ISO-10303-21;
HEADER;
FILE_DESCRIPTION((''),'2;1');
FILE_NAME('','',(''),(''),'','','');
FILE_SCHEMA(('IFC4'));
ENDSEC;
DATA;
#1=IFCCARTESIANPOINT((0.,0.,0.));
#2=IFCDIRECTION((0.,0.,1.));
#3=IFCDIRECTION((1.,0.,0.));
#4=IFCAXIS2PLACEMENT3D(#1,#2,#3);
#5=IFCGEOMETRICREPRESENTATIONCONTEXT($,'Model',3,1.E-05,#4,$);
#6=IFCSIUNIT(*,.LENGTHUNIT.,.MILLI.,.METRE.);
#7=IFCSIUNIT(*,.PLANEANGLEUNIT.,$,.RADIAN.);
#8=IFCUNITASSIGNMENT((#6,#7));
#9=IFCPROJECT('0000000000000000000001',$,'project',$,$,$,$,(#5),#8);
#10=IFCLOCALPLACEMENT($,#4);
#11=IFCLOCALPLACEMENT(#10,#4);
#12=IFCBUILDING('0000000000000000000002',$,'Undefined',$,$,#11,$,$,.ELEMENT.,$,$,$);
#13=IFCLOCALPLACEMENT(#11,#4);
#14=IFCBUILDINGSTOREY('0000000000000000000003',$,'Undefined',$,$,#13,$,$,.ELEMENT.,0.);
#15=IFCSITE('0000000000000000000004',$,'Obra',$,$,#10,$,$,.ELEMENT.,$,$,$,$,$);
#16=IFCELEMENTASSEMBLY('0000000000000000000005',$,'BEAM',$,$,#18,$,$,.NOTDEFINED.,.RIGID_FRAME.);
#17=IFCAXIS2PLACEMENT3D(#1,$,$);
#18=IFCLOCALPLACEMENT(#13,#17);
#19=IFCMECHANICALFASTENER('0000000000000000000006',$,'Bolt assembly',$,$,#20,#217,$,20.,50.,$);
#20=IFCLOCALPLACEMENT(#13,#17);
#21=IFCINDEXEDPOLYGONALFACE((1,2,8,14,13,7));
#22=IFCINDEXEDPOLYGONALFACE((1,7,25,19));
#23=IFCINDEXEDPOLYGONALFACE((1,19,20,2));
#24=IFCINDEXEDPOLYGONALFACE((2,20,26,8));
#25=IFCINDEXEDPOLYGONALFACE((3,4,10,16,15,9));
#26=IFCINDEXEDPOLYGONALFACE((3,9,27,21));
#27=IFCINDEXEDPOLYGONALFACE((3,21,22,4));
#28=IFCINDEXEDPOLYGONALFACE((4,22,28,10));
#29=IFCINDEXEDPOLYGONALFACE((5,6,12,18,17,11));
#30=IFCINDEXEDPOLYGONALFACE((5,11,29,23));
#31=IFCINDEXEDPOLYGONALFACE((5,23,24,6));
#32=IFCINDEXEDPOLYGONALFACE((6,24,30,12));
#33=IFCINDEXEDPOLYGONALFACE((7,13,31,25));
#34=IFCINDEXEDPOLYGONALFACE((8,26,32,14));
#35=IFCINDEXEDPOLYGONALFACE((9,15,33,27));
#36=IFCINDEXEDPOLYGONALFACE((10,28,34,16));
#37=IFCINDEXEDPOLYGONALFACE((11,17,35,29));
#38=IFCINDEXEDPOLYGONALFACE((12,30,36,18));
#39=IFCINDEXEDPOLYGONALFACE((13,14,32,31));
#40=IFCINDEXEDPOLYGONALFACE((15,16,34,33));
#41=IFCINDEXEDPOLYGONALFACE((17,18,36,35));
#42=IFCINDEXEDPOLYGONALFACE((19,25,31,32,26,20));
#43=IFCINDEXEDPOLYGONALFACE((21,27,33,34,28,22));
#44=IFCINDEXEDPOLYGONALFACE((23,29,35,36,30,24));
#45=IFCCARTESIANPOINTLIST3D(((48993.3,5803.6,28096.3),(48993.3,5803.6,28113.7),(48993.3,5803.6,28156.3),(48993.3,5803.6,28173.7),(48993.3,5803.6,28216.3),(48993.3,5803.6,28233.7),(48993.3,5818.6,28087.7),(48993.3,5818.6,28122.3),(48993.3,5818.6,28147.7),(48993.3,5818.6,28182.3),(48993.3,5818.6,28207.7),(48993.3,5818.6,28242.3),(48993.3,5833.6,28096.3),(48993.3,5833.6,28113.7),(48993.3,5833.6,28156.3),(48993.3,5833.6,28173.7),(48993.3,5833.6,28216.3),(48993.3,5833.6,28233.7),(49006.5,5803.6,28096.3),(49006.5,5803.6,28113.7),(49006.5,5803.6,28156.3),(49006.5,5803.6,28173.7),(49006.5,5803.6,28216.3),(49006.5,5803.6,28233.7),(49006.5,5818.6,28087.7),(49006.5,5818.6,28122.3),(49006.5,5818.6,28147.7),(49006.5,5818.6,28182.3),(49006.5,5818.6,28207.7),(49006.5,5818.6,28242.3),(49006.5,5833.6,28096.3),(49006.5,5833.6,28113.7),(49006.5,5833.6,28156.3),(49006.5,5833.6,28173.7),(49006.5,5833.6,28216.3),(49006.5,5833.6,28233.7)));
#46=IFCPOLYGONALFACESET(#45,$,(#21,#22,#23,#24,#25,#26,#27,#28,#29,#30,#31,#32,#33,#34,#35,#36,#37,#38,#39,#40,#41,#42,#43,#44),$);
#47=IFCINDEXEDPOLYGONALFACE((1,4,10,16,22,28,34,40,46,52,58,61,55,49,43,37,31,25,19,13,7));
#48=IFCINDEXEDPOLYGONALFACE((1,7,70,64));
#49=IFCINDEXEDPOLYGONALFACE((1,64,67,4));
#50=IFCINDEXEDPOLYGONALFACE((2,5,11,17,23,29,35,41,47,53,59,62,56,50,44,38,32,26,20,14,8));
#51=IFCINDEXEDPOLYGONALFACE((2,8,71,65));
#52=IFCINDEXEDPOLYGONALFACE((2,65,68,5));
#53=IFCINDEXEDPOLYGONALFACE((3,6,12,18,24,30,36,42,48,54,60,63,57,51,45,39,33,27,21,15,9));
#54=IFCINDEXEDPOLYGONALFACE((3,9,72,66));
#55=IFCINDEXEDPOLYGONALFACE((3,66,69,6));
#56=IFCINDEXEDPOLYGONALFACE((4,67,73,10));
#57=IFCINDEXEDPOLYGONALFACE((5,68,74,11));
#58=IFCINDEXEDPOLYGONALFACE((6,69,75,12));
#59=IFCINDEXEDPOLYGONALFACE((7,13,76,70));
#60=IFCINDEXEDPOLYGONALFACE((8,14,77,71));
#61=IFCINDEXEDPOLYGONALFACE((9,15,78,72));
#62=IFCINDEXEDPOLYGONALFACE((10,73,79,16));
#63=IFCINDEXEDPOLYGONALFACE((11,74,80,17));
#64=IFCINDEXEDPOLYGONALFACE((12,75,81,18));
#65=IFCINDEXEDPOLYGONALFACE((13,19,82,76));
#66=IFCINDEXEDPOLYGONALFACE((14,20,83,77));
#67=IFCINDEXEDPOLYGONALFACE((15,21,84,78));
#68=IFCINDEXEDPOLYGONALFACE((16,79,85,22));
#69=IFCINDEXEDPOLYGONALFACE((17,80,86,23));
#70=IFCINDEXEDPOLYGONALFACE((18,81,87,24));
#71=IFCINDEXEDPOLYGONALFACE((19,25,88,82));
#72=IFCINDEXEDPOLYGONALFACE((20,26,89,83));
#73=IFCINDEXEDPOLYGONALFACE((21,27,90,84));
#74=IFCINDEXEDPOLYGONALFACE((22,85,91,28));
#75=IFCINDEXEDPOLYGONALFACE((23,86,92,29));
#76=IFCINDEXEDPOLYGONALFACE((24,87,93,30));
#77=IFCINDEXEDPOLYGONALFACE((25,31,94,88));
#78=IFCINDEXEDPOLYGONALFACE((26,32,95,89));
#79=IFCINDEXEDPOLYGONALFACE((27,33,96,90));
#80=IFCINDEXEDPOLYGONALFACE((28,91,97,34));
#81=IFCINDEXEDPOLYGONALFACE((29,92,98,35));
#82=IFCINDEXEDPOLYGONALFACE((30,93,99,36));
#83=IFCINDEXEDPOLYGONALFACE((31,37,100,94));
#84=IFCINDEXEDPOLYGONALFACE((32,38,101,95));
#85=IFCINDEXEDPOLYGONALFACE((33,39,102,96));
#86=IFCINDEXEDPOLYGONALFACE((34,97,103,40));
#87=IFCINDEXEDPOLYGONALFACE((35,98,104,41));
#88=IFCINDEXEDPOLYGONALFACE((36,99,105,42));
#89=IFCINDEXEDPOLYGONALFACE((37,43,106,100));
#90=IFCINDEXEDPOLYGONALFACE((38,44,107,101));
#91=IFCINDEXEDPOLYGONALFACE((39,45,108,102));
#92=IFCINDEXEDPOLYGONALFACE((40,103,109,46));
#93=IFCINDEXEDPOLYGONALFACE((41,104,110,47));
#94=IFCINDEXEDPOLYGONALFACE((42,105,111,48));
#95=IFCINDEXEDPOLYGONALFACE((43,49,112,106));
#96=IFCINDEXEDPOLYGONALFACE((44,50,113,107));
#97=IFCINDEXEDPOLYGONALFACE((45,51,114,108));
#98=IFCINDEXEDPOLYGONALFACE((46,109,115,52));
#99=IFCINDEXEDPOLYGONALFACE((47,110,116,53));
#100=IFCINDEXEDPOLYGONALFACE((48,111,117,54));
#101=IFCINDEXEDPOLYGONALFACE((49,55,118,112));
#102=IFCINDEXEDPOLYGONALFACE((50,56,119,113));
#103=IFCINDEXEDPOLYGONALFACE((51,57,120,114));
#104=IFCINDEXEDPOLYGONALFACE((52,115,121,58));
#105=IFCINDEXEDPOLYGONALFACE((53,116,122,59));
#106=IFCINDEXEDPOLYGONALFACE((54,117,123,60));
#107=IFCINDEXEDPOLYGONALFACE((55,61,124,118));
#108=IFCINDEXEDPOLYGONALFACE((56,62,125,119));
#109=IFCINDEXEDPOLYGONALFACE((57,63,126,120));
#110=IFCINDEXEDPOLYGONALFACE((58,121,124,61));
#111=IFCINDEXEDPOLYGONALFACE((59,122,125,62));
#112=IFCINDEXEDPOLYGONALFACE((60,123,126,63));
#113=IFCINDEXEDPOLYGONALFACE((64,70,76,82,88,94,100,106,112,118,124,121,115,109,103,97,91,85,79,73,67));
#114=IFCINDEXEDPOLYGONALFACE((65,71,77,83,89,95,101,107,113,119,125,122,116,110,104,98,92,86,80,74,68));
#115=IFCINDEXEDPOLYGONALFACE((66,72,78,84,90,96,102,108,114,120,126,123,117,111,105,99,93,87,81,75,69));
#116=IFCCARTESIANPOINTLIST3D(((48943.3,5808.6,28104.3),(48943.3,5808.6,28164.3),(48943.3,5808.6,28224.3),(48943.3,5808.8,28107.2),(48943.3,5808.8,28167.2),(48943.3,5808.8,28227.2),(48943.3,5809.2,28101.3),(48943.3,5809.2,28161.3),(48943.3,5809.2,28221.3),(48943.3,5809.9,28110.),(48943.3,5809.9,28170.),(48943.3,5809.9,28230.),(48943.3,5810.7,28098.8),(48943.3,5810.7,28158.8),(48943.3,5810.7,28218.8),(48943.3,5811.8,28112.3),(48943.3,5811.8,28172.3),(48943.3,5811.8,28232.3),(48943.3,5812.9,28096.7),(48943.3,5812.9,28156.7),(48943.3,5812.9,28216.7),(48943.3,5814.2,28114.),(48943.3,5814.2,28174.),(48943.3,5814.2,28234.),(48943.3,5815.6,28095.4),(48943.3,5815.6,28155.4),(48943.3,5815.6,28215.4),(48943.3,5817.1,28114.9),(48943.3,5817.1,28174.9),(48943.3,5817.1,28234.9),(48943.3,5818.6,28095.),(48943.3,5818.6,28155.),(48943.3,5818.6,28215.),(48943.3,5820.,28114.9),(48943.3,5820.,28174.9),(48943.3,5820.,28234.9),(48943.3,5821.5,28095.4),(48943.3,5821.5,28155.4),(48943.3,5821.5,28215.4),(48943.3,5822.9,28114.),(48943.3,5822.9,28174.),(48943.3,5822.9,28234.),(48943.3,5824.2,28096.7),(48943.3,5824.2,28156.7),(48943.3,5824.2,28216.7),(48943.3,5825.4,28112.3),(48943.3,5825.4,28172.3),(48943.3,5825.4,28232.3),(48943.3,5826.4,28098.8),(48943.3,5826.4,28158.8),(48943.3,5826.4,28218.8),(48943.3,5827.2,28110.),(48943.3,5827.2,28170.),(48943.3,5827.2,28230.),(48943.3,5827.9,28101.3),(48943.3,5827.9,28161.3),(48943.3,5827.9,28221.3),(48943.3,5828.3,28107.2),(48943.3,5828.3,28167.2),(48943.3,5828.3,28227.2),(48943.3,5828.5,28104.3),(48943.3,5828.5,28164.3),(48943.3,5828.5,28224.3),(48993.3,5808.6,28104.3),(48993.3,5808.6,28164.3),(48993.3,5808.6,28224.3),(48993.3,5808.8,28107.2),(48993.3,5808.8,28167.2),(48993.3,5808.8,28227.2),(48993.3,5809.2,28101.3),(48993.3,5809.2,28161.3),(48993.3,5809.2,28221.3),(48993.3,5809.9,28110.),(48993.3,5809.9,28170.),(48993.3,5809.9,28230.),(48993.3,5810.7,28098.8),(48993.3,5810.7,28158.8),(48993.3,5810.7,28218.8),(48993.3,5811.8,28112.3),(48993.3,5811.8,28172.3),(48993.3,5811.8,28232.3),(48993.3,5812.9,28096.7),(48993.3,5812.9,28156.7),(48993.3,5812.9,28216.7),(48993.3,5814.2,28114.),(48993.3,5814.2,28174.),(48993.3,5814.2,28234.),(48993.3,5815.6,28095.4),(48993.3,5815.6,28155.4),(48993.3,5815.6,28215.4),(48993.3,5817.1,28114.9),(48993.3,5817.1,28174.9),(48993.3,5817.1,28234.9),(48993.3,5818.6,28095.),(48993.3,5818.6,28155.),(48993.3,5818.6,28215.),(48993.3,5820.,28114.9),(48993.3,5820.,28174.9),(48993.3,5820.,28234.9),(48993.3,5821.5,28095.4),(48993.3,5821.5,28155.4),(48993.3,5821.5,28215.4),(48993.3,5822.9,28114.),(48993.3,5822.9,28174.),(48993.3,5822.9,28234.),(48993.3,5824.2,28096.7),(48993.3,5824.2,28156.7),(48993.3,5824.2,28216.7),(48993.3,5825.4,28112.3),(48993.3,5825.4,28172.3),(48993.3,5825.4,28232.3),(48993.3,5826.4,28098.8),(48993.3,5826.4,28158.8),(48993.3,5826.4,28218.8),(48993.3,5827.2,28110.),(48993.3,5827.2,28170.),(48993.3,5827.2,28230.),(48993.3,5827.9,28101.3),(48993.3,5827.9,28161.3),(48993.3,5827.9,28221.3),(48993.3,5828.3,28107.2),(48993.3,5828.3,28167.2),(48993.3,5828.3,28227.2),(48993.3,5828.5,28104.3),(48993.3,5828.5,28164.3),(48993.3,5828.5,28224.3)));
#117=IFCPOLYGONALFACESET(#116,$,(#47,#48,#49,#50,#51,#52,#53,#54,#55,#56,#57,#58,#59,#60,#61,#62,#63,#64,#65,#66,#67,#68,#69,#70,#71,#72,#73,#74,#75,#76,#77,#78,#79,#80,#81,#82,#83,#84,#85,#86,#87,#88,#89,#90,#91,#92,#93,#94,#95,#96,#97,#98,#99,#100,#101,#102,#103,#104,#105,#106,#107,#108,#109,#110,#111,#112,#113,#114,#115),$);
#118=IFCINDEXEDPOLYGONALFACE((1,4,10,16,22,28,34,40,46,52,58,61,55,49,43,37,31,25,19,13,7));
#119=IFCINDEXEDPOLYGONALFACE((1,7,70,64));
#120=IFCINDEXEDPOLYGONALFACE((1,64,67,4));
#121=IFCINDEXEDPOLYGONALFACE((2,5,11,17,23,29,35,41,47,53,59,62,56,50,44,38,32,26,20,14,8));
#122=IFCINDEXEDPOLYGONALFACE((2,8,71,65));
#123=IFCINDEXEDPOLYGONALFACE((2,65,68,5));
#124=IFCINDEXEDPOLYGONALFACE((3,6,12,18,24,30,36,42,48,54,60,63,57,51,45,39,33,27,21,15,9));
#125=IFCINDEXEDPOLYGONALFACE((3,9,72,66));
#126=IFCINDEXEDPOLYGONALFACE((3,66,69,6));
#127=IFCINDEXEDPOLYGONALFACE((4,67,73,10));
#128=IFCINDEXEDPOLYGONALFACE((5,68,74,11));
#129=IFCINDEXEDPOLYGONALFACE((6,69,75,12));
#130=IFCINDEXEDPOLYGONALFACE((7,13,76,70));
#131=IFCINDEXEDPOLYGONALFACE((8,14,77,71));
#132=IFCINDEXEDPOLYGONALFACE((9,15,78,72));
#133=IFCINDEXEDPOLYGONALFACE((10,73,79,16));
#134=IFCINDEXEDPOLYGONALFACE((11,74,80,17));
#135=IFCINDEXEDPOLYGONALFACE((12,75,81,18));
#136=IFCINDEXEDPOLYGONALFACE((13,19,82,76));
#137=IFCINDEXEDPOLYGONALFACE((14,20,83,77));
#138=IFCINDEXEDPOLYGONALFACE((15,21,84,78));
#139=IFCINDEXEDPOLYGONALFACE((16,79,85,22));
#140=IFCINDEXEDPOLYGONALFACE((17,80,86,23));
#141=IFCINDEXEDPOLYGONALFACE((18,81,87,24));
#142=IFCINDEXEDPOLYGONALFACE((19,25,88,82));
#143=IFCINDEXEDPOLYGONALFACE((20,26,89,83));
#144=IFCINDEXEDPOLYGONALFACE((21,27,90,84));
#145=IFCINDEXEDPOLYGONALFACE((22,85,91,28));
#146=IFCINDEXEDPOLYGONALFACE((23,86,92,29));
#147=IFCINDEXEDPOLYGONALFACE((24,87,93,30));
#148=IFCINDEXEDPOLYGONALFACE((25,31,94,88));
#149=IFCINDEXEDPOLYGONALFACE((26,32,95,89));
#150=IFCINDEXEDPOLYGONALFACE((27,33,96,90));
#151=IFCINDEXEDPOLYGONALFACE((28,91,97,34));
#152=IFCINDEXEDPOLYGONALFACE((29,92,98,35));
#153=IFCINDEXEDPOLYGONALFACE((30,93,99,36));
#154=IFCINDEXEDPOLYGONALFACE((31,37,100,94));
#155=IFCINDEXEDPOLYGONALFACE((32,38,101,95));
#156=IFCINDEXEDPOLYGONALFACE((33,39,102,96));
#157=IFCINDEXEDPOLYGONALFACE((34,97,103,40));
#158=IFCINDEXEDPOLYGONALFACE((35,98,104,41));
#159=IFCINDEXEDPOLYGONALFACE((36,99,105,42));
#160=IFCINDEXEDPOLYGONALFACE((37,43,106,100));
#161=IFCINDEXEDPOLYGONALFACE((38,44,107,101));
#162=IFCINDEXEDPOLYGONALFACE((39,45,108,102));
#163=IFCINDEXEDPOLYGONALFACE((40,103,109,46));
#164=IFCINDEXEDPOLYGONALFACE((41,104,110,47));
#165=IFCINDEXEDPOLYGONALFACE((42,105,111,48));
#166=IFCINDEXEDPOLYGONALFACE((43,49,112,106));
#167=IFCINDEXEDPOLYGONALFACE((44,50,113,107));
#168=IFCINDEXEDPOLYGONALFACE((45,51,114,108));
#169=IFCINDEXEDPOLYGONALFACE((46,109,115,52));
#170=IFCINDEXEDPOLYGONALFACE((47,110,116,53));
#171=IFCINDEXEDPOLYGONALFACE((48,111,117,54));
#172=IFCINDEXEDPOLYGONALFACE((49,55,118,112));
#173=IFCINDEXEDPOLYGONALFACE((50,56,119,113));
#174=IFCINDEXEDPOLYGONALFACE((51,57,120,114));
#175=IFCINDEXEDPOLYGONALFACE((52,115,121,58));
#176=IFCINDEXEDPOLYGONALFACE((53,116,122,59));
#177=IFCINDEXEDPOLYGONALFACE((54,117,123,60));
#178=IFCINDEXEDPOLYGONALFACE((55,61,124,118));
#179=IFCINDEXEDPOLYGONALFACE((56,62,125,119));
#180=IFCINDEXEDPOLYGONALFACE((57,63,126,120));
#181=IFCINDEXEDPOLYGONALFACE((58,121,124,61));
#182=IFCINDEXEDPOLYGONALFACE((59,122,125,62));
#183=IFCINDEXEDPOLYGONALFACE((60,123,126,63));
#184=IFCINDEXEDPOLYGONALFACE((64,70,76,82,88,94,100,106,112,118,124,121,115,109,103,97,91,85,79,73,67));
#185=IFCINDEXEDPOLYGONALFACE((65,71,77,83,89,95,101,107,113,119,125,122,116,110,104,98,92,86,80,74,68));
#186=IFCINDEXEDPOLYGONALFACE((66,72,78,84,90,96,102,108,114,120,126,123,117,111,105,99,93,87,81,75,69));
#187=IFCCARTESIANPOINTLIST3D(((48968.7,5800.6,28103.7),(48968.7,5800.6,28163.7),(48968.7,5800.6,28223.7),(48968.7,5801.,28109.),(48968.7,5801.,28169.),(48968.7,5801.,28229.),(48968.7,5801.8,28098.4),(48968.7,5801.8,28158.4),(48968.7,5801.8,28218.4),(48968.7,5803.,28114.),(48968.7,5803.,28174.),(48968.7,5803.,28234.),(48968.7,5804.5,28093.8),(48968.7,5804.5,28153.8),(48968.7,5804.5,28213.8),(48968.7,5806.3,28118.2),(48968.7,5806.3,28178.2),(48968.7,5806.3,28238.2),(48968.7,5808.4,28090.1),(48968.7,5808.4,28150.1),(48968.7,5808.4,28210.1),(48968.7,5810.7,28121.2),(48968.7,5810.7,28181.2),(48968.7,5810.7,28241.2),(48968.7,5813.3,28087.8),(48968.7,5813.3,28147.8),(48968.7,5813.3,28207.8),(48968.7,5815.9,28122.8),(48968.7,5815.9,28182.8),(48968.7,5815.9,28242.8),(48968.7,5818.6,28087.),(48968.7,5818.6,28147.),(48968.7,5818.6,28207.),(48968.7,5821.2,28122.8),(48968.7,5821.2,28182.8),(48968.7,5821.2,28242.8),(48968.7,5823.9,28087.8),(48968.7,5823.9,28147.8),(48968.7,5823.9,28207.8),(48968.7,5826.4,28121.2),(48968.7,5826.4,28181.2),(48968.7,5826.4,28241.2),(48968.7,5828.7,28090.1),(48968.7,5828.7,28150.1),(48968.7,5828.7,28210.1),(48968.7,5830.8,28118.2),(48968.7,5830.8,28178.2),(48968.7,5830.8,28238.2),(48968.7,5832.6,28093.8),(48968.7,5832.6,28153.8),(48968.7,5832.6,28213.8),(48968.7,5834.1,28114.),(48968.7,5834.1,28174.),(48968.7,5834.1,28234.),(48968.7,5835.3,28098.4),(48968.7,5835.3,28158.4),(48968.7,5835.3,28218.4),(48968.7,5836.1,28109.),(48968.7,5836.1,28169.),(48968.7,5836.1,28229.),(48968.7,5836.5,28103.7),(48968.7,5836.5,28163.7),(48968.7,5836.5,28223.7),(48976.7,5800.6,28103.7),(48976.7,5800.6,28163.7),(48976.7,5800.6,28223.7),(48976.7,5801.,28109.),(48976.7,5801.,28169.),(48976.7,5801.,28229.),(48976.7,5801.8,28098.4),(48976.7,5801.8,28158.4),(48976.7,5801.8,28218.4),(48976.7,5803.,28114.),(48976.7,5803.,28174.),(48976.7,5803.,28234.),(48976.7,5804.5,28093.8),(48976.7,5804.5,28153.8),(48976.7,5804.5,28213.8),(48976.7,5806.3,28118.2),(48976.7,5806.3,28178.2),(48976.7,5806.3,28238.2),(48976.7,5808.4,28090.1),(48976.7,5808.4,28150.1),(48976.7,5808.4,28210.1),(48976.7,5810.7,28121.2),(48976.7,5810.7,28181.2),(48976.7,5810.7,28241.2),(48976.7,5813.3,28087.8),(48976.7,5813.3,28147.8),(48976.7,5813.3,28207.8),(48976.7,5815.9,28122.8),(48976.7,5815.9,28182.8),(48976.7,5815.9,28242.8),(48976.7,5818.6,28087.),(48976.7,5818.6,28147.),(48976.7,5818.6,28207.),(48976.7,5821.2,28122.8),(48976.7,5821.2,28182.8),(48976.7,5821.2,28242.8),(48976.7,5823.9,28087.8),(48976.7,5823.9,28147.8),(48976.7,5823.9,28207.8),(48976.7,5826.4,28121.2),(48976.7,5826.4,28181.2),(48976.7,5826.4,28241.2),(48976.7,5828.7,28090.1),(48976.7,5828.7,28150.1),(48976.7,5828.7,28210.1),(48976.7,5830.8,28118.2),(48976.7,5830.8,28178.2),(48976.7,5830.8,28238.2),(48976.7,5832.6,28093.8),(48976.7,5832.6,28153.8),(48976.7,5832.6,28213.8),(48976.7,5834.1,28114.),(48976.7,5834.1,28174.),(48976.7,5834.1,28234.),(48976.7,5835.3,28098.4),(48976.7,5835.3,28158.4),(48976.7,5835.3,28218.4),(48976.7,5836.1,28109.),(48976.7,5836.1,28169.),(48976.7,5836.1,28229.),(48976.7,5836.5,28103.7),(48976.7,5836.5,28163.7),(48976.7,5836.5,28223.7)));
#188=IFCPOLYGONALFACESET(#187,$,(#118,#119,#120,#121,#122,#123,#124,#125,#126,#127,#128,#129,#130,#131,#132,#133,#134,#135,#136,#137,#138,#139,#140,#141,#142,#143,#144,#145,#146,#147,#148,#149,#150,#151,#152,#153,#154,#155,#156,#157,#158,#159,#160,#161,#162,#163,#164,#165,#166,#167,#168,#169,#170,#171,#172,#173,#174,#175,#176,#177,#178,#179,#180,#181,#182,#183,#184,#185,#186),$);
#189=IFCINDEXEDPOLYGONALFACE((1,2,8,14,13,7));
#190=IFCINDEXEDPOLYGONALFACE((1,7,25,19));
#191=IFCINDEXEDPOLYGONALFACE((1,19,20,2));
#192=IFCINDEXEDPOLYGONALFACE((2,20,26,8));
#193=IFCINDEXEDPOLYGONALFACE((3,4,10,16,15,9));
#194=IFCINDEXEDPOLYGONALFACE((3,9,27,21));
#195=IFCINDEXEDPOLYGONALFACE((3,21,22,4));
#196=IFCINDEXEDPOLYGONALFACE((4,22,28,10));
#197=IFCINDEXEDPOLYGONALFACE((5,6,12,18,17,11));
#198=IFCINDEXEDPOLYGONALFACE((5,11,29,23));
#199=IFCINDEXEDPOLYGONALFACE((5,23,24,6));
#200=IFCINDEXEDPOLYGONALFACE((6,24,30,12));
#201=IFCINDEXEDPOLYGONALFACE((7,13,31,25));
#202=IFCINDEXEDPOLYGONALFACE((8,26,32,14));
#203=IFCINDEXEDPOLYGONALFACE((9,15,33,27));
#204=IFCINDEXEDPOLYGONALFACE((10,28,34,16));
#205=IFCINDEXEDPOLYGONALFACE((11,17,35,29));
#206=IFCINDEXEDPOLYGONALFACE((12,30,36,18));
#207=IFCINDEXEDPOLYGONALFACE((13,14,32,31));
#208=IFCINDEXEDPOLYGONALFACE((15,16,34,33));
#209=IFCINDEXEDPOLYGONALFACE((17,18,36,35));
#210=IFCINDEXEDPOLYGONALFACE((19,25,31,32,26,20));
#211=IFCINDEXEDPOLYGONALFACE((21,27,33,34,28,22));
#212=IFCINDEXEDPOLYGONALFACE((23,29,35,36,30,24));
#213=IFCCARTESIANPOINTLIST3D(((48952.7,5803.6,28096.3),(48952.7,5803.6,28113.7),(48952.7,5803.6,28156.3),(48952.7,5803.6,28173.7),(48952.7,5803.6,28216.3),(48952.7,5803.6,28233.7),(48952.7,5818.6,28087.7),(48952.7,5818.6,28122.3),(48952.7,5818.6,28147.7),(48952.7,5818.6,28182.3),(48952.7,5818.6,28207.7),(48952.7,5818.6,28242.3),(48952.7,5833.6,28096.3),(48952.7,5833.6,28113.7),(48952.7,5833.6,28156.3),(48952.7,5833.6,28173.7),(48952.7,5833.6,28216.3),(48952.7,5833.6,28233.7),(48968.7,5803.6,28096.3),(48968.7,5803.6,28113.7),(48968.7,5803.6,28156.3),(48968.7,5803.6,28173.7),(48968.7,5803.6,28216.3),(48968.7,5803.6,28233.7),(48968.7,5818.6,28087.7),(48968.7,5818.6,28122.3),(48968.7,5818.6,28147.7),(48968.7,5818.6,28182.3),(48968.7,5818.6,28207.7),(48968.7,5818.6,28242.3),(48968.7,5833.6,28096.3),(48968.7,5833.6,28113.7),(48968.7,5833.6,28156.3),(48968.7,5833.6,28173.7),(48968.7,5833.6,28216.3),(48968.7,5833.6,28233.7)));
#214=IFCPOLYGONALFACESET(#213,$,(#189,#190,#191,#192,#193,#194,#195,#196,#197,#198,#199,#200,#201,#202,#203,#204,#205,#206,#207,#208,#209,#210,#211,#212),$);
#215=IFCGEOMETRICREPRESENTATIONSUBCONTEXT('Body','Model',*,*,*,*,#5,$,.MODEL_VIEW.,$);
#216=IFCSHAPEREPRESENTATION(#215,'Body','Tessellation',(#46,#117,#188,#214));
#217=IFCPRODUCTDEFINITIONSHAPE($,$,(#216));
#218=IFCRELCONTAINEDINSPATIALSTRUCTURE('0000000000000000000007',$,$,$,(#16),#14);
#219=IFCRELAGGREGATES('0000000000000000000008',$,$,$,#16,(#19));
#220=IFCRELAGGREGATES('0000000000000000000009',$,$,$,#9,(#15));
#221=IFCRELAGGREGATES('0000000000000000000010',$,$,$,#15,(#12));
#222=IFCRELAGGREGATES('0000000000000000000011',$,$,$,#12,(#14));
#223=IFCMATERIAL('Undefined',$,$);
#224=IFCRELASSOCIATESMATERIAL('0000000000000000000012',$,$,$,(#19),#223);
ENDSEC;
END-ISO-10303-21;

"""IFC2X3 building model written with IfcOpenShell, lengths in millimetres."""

from ifc_helpers import new_model, si_unit, frame, origin_with_axes, origin_2d_with_axis, place, context, subcontext, project, spatial, polyline, circle, outline, extrude, source, transform, mapped, material, element, aggregate, save


model = new_model("IFC2X3")

# Units and contexts
model_context = context("Model", 3, precision=1e-05, world=origin_with_axes())
body_context = subcontext(model_context, "Body", "Model", "MODEL_VIEW")
ifc_project = project(units=[si_unit("LENGTHUNIT", "METRE", prefix="MILLI"), si_unit("PLANEANGLEUNIT", "RADIAN")], contexts=[model_context])

# Site, building, storey
site_placement = place(None, origin_with_axes())
site = spatial("IfcSite", under=ifc_project, at=site_placement, Name="Obra", CompositionType="ELEMENT")
building_placement = place(site_placement, origin_with_axes())
building = spatial("IfcBuilding", under=site, at=building_placement, Name="Undefined", CompositionType="ELEMENT")
storey_placement = place(building_placement, origin_with_axes())
storey = spatial("IfcBuildingStorey", under=building, at=storey_placement, Name="Undefined", CompositionType="ELEMENT", Elevation=0.0)

# Shared definitions
ifc_material_1 = material(Name="Undefined")

# Element assembly, mechanical fastener
shared_shape_1 = source(origin_with_axes(), body_context, "Body", "SweptSolid", [
    extrude(outline(polyline([(17.3, 0.0), (8.7, 15.0), (-8.7, 15.0), (-17.3, 0.0), (-8.7, -15.0), (8.7, -15.0), (17.3, 0.0)])), frame((0.0, -26.5, 0.0), z_axis=(0.0, 1.0, 0.0), x_axis=(1.0, 0.0, 0.0)), (0.0, 0.0, 1.0), 13.2),
    extrude(circle(Radius=10.0, at=origin_2d_with_axis()), frame((0.0, -13.3, 0.0), z_axis=(0.0, 1.0, 0.0), x_axis=(1.0, 0.0, 0.0)), (0.0, 0.0, 1.0), 50.0),
    extrude(circle(Radius=18.0, at=origin_2d_with_axis()), frame((0.0, 3.3, 0.0), z_axis=(0.0, 1.0, 0.0), x_axis=(1.0, 0.0, 0.0)), (0.0, 0.0, 1.0), 8.0),
    extrude(outline(polyline([(17.3, 0.0), (8.7, 15.0), (-8.7, 15.0), (-17.3, 0.0), (-8.7, -15.0), (8.7, -15.0), (17.3, 0.0)])), frame((0.0, 11.3, 0.0), z_axis=(0.0, 1.0, 0.0), x_axis=(1.0, 0.0, 0.0)), (0.0, 0.0, 1.0), 16.0),
])
assembly_1_placement = place(storey_placement, origin_with_axes())
assembly_1 = element("IfcElementAssembly", 1, at=assembly_1_placement, inside=storey, Name="BEAM", AssemblyPlace="NOTDEFINED", PredefinedType="RIGID_FRAME")
mechanical_fastener_1_placement = place(assembly_1_placement, frame((48980.0, 5768.6, 28265.0), z_axis=(0.0, 1.0, 0.0), x_axis=(0.0, 0.0, -1.0)))
mechanical_fastener_1 = element("IfcMechanicalFastener", 2, at=mechanical_fastener_1_placement, material=ifc_material_1, Name="Bolt assembly", NominalDiameter=20.0, NominalLength=50.0, context=body_context, shape_type="MappedRepresentation", body=[
    mapped(shared_shape_1, transform((40.0, 0.0, 50.0))),
    mapped(shared_shape_1, transform((100.0, 0.0, 50.0))),
    mapped(shared_shape_1, transform((160.0, 0.0, 50.0))),
])
aggregate(assembly_1, [mechanical_fastener_1])

save(model, "model.ifc")
